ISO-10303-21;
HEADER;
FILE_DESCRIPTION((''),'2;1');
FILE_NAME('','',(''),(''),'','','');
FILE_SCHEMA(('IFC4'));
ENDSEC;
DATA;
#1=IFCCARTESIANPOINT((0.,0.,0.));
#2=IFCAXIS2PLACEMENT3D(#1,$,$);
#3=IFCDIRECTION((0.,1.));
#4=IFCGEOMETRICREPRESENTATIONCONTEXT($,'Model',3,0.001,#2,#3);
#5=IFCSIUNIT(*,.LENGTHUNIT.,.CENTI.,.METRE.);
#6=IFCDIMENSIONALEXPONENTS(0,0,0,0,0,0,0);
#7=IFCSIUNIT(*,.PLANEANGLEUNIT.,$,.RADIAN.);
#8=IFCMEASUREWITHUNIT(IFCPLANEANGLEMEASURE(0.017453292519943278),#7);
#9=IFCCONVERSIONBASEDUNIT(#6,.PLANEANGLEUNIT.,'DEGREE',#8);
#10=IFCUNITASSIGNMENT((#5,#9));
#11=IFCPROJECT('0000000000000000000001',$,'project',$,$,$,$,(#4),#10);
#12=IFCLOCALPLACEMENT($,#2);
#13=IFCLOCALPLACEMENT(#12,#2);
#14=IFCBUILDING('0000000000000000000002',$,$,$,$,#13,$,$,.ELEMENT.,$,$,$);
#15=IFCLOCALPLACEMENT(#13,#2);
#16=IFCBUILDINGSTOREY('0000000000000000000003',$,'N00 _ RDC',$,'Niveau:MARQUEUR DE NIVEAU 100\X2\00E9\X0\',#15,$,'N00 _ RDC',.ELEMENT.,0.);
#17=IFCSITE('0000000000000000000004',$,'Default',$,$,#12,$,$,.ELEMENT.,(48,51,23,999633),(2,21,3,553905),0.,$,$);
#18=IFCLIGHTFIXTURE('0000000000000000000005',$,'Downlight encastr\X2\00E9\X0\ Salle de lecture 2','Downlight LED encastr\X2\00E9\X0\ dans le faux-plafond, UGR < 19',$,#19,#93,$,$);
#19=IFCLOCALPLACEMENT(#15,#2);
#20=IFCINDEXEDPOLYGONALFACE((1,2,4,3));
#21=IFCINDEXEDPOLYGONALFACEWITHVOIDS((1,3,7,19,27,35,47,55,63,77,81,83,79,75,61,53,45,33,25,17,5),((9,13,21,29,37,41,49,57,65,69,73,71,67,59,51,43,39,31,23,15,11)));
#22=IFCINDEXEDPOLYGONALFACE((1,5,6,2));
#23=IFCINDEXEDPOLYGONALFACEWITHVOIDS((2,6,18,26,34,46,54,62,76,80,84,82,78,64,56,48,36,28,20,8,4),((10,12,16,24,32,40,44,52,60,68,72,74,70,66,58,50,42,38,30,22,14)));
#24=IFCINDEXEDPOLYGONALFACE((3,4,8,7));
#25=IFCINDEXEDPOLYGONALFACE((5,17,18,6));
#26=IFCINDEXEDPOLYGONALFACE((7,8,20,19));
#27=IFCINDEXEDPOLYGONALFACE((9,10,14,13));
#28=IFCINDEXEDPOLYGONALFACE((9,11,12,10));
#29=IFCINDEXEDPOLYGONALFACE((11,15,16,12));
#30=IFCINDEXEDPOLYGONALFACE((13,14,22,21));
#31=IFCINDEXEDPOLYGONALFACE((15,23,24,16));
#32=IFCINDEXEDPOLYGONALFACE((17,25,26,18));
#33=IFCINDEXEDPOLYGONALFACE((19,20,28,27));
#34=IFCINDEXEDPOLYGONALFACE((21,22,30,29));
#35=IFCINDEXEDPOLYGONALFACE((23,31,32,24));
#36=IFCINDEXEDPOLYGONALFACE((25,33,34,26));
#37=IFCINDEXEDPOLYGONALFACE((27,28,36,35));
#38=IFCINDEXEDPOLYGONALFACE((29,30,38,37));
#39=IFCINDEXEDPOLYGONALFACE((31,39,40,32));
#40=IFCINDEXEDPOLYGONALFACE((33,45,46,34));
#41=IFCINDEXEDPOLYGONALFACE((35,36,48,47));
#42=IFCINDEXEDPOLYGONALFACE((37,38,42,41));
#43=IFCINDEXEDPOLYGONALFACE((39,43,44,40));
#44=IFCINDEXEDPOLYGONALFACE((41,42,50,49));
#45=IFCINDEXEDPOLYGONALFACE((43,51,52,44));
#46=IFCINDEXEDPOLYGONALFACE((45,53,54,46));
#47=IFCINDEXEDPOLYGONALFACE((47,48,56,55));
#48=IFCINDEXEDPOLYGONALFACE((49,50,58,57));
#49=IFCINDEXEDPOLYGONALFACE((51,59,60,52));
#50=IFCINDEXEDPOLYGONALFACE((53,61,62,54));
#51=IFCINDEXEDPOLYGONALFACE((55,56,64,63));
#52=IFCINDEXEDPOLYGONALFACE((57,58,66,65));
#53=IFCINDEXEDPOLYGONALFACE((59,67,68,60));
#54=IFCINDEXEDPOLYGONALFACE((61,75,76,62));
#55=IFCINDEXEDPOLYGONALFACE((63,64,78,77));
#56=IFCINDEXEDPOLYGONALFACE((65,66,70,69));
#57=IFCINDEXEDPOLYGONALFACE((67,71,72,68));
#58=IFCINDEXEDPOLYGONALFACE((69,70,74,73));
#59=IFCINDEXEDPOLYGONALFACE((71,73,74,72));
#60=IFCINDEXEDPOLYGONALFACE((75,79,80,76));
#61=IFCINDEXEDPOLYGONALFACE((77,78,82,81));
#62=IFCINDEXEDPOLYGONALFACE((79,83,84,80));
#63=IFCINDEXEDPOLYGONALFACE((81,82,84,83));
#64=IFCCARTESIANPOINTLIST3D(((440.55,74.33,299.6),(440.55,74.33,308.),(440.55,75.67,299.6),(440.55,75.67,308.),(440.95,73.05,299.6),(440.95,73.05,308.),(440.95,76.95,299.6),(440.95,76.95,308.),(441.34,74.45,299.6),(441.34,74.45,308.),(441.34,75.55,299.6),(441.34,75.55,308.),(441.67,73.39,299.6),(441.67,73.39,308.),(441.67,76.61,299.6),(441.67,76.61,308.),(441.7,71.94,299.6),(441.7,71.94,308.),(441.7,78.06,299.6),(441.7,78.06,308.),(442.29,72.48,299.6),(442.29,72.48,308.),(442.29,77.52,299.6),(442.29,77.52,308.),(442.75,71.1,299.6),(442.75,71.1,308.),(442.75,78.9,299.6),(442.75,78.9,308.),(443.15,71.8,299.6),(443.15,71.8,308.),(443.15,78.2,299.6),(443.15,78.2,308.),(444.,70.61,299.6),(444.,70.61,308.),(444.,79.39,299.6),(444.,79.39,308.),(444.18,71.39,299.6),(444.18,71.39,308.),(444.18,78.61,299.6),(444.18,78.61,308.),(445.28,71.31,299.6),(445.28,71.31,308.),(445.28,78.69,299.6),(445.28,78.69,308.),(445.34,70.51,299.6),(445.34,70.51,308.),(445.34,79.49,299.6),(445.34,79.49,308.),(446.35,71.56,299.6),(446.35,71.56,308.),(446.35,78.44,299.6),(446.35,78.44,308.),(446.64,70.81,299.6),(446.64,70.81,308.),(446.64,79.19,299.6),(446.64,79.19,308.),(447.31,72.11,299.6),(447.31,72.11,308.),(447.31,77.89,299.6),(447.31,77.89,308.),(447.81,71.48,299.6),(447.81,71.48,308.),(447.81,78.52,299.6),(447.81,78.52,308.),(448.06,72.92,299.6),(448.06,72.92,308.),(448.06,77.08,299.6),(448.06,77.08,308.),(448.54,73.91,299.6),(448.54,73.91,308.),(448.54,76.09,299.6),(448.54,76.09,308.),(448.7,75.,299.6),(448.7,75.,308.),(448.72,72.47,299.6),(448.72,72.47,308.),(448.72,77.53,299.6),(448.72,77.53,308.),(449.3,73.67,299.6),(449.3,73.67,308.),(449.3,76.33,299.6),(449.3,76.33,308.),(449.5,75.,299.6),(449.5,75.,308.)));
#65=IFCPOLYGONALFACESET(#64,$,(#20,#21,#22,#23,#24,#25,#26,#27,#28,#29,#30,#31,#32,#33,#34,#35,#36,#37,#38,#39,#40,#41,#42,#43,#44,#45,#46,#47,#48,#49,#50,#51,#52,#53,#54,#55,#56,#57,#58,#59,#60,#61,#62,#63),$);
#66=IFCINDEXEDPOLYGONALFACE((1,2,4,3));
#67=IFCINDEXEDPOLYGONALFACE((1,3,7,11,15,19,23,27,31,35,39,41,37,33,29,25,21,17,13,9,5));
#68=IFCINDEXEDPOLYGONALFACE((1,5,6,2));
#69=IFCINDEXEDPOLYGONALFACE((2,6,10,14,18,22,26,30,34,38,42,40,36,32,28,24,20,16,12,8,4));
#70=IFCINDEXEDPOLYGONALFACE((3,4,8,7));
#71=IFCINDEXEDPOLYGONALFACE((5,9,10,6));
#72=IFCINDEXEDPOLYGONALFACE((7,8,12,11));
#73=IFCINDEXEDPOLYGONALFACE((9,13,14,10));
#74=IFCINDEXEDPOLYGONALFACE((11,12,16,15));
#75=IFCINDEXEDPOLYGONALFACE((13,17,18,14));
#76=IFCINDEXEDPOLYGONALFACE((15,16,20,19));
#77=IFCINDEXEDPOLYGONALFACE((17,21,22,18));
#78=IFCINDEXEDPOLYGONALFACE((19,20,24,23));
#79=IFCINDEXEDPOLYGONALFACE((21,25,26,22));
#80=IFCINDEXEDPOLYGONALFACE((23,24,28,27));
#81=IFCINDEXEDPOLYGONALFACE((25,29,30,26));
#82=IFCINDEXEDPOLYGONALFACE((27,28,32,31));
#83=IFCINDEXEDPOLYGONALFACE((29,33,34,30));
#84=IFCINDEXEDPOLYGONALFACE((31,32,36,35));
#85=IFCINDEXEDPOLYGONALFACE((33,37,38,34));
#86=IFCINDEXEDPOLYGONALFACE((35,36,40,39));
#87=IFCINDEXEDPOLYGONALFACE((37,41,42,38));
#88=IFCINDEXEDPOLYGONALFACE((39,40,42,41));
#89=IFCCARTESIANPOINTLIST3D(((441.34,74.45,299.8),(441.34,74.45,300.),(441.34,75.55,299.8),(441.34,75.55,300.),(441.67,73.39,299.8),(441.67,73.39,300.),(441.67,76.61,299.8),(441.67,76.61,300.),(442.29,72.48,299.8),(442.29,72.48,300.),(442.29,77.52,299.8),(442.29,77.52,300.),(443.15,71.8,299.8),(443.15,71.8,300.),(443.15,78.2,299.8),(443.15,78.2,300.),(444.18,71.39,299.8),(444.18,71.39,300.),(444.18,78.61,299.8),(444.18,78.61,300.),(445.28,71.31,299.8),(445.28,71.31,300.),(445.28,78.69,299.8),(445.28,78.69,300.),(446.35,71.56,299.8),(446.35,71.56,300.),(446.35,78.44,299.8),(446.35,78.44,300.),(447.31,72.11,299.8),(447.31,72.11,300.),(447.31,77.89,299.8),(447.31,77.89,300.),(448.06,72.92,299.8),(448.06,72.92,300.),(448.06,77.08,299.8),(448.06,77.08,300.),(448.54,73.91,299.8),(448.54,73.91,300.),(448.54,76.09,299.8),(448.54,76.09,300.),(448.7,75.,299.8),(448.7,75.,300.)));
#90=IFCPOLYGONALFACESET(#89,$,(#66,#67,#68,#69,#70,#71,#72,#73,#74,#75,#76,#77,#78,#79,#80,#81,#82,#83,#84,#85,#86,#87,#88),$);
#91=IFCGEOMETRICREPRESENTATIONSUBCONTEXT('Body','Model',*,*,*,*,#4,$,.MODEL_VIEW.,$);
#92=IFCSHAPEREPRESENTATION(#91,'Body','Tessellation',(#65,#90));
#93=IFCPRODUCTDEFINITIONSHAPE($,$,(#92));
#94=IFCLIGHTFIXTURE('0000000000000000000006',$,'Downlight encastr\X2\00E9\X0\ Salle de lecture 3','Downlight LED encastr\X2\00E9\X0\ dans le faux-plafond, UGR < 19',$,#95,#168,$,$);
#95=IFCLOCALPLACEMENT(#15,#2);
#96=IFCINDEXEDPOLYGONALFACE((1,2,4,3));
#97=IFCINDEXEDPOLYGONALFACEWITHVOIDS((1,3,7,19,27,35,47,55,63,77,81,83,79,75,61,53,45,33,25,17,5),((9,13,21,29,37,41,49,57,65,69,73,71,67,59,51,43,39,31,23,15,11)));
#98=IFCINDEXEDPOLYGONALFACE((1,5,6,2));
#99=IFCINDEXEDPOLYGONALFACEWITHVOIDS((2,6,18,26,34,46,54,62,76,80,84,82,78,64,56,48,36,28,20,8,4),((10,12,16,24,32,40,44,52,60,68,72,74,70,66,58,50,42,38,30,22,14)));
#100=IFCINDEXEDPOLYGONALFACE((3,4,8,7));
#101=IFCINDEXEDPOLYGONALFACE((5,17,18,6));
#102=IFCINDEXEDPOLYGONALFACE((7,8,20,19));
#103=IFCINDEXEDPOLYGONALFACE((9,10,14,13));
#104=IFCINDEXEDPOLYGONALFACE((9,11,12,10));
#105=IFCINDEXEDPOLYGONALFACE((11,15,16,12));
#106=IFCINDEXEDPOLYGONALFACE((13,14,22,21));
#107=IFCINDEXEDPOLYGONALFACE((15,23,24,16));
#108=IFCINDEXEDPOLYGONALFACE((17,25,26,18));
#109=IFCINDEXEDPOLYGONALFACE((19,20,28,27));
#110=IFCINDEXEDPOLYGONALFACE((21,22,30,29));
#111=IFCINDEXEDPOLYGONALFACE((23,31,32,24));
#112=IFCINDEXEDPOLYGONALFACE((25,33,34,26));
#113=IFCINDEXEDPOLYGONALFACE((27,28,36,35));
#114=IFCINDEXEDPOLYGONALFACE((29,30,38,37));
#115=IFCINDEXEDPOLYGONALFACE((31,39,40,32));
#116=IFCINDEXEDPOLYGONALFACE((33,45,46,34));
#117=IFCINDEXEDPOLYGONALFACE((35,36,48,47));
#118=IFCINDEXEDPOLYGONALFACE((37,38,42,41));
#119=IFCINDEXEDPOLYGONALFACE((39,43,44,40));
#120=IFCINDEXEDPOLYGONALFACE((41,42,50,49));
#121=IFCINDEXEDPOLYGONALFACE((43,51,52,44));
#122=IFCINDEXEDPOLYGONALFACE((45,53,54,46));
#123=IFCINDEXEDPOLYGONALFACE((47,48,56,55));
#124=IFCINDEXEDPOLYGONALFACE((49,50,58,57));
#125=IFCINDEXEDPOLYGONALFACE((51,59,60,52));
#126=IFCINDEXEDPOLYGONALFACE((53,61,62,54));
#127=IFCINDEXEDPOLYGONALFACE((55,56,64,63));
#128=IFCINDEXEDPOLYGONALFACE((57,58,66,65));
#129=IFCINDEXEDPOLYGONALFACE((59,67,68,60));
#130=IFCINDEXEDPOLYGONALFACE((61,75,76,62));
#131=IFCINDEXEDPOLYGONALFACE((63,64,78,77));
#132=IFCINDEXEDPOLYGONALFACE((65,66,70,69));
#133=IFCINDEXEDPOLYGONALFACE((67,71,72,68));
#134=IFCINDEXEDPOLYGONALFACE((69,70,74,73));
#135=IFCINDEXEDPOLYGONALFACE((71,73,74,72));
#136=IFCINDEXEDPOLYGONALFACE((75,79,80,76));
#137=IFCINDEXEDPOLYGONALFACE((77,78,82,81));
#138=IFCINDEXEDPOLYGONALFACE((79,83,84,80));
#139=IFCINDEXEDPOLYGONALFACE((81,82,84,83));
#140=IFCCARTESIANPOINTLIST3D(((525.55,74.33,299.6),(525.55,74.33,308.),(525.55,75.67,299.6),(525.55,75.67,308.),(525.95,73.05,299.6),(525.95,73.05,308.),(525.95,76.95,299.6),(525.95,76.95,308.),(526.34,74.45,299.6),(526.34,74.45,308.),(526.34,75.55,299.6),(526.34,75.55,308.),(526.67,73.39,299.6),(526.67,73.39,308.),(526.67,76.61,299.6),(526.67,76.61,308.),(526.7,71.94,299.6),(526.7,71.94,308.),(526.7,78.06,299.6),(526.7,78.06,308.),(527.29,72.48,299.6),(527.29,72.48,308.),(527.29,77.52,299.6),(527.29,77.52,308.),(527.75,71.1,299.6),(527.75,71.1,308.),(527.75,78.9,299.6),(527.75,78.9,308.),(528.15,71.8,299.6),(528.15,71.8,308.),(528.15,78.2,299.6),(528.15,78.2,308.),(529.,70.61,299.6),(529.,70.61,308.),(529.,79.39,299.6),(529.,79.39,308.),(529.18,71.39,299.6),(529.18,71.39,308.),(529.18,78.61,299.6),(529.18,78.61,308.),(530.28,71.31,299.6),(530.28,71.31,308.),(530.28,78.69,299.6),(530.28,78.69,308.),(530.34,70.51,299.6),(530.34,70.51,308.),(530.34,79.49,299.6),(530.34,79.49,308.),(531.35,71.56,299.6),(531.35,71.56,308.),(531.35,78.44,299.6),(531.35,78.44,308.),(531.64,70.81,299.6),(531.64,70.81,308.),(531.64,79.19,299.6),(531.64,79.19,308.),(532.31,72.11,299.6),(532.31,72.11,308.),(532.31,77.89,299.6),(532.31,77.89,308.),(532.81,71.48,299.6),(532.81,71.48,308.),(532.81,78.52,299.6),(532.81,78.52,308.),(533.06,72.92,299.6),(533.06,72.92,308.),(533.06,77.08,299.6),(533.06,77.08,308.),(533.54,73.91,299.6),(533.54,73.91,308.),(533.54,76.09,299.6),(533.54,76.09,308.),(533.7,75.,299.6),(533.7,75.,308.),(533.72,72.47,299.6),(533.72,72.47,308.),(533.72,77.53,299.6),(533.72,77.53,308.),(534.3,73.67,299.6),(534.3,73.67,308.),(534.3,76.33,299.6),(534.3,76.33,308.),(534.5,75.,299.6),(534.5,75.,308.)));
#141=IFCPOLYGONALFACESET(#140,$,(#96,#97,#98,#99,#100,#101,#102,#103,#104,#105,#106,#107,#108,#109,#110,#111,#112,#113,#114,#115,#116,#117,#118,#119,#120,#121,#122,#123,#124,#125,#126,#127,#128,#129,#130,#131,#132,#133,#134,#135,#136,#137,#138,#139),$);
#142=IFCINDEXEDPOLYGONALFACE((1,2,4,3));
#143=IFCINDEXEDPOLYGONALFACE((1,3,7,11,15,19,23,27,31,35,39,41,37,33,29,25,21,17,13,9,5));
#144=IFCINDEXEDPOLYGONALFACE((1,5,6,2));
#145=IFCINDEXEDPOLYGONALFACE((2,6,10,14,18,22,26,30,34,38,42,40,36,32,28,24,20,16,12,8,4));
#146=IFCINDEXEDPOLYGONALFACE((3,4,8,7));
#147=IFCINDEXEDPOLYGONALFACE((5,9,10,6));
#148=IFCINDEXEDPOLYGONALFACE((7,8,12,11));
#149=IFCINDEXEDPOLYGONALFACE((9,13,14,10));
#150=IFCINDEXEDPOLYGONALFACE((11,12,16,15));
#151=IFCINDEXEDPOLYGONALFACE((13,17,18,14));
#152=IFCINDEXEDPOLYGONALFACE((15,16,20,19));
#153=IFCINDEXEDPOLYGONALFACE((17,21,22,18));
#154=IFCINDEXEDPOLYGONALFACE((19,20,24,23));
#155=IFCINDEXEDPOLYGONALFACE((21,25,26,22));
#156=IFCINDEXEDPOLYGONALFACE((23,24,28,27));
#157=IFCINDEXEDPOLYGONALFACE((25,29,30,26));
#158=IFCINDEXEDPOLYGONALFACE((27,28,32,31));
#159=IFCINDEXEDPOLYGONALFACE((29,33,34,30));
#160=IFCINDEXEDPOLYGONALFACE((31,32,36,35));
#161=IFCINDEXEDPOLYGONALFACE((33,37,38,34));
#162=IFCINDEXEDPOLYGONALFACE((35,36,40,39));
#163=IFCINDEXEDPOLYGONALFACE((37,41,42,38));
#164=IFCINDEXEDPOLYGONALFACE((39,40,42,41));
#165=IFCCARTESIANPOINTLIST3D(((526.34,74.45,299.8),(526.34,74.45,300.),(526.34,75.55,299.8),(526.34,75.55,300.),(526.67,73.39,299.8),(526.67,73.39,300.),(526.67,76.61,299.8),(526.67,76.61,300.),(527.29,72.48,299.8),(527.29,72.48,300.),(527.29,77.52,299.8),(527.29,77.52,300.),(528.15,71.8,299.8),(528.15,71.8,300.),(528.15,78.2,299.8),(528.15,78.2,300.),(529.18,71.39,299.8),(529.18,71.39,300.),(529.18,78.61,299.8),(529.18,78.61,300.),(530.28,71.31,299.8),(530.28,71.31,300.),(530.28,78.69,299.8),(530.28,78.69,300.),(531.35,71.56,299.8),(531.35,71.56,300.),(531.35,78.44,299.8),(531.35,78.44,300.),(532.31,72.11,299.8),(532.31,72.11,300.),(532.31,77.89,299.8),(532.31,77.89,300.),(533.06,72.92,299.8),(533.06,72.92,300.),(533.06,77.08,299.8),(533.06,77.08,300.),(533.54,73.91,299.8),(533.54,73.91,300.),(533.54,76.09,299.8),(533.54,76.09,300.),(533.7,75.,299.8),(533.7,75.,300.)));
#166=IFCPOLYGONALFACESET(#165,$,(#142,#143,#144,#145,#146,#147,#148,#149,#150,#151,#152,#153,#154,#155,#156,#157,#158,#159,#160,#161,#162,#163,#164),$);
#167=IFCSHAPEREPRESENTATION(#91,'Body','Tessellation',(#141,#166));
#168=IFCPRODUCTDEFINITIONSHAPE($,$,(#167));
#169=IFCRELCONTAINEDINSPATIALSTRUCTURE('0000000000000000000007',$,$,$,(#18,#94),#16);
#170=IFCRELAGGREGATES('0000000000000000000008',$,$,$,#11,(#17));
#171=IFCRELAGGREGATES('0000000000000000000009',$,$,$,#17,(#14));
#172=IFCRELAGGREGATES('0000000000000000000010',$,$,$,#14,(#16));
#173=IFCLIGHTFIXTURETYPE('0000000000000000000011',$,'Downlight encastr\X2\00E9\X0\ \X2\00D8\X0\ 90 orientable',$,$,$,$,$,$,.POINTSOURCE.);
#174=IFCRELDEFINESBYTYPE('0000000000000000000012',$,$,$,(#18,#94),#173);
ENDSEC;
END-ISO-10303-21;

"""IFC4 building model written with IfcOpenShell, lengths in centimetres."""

from ifc_helpers import new_model, entity, si_unit, converted_unit, direction, frame, frame_2d, origin, origin_with_axes, place, context, subcontext, project, spatial, circle, hollow_circle, extrude, type_object, element, save


model = new_model("IFC4")

# Units and contexts
model_context = context("Model", 3, precision=0.001, world=origin(), true_north=direction((0.0, 1.0)))
body_context = subcontext(model_context, "Body", "Model", "MODEL_VIEW")
ifc_project = project(units=[si_unit("LENGTHUNIT", "METRE", prefix="CENTI"), converted_unit("PLANEANGLEUNIT", "DEGREE", entity("IfcPlaneAngleMeasure", 0.017453292519943278), si_unit("PLANEANGLEUNIT", "RADIAN"), dimensions=[0, 0, 0, 0, 0, 0, 0])], contexts=[model_context])

# Site, building, storey
site_placement = place(None, origin())
site = spatial("IfcSite", under=ifc_project, at=site_placement, Name="Default", CompositionType="ELEMENT", RefLatitude=(48, 51, 23, 999633), RefLongitude=(2, 21, 3, 553905), RefElevation=0.0)
building_placement = place(site_placement, origin())
building = spatial("IfcBuilding", under=site, at=building_placement, CompositionType="ELEMENT")
storey_placement = place(building_placement, origin())
storey = spatial("IfcBuildingStorey", under=building, at=storey_placement, Name="N00 _ RDC", ObjectType="Niveau:MARQUEUR DE NIVEAU 100é", LongName="N00 _ RDC", CompositionType="ELEMENT", Elevation=0.0)

# Light fixtures
light_fixture_type_1 = type_object("IfcLightFixtureType", Name="Downlight encastré Ø 90 orientable", PredefinedType="POINTSOURCE")
light_fixture_1_placement = place(storey_placement, origin_with_axes())
element("IfcLightFixture", 1, at=light_fixture_1_placement, inside=storey, type_object=light_fixture_type_1, Name="Downlight encastré Salle de lecture 2", Description="Downlight LED encastré dans le faux-plafond, UGR < 19", context=body_context, shape_type="SweptSolid", body=[
    extrude(hollow_circle(Radius=4.5, WallThickness=0.8, at=frame_2d((445.0, 75.0))), frame((0.0, 0.0, 299.6)), (0.0, 0.0, 1.0), 8.4),
    extrude(circle(Radius=3.7, at=frame_2d((445.0, 75.0))), frame((0.0, 0.0, 299.8)), (0.0, 0.0, 1.0), 0.2),
])
light_fixture_2_placement = place(storey_placement, origin_with_axes())
element("IfcLightFixture", 2, at=light_fixture_2_placement, inside=storey, type_object=light_fixture_type_1, Name="Downlight encastré Salle de lecture 3", Description="Downlight LED encastré dans le faux-plafond, UGR < 19", context=body_context, shape_type="SweptSolid", body=[
    extrude(hollow_circle(Radius=4.5, WallThickness=0.8, at=frame_2d((530.0, 75.0))), frame((0.0, 0.0, 299.6)), (0.0, 0.0, 1.0), 8.4),
    extrude(circle(Radius=3.7, at=frame_2d((530.0, 75.0))), frame((0.0, 0.0, 299.8)), (0.0, 0.0, 1.0), 0.2),
])

save(model, "model.ifc")
